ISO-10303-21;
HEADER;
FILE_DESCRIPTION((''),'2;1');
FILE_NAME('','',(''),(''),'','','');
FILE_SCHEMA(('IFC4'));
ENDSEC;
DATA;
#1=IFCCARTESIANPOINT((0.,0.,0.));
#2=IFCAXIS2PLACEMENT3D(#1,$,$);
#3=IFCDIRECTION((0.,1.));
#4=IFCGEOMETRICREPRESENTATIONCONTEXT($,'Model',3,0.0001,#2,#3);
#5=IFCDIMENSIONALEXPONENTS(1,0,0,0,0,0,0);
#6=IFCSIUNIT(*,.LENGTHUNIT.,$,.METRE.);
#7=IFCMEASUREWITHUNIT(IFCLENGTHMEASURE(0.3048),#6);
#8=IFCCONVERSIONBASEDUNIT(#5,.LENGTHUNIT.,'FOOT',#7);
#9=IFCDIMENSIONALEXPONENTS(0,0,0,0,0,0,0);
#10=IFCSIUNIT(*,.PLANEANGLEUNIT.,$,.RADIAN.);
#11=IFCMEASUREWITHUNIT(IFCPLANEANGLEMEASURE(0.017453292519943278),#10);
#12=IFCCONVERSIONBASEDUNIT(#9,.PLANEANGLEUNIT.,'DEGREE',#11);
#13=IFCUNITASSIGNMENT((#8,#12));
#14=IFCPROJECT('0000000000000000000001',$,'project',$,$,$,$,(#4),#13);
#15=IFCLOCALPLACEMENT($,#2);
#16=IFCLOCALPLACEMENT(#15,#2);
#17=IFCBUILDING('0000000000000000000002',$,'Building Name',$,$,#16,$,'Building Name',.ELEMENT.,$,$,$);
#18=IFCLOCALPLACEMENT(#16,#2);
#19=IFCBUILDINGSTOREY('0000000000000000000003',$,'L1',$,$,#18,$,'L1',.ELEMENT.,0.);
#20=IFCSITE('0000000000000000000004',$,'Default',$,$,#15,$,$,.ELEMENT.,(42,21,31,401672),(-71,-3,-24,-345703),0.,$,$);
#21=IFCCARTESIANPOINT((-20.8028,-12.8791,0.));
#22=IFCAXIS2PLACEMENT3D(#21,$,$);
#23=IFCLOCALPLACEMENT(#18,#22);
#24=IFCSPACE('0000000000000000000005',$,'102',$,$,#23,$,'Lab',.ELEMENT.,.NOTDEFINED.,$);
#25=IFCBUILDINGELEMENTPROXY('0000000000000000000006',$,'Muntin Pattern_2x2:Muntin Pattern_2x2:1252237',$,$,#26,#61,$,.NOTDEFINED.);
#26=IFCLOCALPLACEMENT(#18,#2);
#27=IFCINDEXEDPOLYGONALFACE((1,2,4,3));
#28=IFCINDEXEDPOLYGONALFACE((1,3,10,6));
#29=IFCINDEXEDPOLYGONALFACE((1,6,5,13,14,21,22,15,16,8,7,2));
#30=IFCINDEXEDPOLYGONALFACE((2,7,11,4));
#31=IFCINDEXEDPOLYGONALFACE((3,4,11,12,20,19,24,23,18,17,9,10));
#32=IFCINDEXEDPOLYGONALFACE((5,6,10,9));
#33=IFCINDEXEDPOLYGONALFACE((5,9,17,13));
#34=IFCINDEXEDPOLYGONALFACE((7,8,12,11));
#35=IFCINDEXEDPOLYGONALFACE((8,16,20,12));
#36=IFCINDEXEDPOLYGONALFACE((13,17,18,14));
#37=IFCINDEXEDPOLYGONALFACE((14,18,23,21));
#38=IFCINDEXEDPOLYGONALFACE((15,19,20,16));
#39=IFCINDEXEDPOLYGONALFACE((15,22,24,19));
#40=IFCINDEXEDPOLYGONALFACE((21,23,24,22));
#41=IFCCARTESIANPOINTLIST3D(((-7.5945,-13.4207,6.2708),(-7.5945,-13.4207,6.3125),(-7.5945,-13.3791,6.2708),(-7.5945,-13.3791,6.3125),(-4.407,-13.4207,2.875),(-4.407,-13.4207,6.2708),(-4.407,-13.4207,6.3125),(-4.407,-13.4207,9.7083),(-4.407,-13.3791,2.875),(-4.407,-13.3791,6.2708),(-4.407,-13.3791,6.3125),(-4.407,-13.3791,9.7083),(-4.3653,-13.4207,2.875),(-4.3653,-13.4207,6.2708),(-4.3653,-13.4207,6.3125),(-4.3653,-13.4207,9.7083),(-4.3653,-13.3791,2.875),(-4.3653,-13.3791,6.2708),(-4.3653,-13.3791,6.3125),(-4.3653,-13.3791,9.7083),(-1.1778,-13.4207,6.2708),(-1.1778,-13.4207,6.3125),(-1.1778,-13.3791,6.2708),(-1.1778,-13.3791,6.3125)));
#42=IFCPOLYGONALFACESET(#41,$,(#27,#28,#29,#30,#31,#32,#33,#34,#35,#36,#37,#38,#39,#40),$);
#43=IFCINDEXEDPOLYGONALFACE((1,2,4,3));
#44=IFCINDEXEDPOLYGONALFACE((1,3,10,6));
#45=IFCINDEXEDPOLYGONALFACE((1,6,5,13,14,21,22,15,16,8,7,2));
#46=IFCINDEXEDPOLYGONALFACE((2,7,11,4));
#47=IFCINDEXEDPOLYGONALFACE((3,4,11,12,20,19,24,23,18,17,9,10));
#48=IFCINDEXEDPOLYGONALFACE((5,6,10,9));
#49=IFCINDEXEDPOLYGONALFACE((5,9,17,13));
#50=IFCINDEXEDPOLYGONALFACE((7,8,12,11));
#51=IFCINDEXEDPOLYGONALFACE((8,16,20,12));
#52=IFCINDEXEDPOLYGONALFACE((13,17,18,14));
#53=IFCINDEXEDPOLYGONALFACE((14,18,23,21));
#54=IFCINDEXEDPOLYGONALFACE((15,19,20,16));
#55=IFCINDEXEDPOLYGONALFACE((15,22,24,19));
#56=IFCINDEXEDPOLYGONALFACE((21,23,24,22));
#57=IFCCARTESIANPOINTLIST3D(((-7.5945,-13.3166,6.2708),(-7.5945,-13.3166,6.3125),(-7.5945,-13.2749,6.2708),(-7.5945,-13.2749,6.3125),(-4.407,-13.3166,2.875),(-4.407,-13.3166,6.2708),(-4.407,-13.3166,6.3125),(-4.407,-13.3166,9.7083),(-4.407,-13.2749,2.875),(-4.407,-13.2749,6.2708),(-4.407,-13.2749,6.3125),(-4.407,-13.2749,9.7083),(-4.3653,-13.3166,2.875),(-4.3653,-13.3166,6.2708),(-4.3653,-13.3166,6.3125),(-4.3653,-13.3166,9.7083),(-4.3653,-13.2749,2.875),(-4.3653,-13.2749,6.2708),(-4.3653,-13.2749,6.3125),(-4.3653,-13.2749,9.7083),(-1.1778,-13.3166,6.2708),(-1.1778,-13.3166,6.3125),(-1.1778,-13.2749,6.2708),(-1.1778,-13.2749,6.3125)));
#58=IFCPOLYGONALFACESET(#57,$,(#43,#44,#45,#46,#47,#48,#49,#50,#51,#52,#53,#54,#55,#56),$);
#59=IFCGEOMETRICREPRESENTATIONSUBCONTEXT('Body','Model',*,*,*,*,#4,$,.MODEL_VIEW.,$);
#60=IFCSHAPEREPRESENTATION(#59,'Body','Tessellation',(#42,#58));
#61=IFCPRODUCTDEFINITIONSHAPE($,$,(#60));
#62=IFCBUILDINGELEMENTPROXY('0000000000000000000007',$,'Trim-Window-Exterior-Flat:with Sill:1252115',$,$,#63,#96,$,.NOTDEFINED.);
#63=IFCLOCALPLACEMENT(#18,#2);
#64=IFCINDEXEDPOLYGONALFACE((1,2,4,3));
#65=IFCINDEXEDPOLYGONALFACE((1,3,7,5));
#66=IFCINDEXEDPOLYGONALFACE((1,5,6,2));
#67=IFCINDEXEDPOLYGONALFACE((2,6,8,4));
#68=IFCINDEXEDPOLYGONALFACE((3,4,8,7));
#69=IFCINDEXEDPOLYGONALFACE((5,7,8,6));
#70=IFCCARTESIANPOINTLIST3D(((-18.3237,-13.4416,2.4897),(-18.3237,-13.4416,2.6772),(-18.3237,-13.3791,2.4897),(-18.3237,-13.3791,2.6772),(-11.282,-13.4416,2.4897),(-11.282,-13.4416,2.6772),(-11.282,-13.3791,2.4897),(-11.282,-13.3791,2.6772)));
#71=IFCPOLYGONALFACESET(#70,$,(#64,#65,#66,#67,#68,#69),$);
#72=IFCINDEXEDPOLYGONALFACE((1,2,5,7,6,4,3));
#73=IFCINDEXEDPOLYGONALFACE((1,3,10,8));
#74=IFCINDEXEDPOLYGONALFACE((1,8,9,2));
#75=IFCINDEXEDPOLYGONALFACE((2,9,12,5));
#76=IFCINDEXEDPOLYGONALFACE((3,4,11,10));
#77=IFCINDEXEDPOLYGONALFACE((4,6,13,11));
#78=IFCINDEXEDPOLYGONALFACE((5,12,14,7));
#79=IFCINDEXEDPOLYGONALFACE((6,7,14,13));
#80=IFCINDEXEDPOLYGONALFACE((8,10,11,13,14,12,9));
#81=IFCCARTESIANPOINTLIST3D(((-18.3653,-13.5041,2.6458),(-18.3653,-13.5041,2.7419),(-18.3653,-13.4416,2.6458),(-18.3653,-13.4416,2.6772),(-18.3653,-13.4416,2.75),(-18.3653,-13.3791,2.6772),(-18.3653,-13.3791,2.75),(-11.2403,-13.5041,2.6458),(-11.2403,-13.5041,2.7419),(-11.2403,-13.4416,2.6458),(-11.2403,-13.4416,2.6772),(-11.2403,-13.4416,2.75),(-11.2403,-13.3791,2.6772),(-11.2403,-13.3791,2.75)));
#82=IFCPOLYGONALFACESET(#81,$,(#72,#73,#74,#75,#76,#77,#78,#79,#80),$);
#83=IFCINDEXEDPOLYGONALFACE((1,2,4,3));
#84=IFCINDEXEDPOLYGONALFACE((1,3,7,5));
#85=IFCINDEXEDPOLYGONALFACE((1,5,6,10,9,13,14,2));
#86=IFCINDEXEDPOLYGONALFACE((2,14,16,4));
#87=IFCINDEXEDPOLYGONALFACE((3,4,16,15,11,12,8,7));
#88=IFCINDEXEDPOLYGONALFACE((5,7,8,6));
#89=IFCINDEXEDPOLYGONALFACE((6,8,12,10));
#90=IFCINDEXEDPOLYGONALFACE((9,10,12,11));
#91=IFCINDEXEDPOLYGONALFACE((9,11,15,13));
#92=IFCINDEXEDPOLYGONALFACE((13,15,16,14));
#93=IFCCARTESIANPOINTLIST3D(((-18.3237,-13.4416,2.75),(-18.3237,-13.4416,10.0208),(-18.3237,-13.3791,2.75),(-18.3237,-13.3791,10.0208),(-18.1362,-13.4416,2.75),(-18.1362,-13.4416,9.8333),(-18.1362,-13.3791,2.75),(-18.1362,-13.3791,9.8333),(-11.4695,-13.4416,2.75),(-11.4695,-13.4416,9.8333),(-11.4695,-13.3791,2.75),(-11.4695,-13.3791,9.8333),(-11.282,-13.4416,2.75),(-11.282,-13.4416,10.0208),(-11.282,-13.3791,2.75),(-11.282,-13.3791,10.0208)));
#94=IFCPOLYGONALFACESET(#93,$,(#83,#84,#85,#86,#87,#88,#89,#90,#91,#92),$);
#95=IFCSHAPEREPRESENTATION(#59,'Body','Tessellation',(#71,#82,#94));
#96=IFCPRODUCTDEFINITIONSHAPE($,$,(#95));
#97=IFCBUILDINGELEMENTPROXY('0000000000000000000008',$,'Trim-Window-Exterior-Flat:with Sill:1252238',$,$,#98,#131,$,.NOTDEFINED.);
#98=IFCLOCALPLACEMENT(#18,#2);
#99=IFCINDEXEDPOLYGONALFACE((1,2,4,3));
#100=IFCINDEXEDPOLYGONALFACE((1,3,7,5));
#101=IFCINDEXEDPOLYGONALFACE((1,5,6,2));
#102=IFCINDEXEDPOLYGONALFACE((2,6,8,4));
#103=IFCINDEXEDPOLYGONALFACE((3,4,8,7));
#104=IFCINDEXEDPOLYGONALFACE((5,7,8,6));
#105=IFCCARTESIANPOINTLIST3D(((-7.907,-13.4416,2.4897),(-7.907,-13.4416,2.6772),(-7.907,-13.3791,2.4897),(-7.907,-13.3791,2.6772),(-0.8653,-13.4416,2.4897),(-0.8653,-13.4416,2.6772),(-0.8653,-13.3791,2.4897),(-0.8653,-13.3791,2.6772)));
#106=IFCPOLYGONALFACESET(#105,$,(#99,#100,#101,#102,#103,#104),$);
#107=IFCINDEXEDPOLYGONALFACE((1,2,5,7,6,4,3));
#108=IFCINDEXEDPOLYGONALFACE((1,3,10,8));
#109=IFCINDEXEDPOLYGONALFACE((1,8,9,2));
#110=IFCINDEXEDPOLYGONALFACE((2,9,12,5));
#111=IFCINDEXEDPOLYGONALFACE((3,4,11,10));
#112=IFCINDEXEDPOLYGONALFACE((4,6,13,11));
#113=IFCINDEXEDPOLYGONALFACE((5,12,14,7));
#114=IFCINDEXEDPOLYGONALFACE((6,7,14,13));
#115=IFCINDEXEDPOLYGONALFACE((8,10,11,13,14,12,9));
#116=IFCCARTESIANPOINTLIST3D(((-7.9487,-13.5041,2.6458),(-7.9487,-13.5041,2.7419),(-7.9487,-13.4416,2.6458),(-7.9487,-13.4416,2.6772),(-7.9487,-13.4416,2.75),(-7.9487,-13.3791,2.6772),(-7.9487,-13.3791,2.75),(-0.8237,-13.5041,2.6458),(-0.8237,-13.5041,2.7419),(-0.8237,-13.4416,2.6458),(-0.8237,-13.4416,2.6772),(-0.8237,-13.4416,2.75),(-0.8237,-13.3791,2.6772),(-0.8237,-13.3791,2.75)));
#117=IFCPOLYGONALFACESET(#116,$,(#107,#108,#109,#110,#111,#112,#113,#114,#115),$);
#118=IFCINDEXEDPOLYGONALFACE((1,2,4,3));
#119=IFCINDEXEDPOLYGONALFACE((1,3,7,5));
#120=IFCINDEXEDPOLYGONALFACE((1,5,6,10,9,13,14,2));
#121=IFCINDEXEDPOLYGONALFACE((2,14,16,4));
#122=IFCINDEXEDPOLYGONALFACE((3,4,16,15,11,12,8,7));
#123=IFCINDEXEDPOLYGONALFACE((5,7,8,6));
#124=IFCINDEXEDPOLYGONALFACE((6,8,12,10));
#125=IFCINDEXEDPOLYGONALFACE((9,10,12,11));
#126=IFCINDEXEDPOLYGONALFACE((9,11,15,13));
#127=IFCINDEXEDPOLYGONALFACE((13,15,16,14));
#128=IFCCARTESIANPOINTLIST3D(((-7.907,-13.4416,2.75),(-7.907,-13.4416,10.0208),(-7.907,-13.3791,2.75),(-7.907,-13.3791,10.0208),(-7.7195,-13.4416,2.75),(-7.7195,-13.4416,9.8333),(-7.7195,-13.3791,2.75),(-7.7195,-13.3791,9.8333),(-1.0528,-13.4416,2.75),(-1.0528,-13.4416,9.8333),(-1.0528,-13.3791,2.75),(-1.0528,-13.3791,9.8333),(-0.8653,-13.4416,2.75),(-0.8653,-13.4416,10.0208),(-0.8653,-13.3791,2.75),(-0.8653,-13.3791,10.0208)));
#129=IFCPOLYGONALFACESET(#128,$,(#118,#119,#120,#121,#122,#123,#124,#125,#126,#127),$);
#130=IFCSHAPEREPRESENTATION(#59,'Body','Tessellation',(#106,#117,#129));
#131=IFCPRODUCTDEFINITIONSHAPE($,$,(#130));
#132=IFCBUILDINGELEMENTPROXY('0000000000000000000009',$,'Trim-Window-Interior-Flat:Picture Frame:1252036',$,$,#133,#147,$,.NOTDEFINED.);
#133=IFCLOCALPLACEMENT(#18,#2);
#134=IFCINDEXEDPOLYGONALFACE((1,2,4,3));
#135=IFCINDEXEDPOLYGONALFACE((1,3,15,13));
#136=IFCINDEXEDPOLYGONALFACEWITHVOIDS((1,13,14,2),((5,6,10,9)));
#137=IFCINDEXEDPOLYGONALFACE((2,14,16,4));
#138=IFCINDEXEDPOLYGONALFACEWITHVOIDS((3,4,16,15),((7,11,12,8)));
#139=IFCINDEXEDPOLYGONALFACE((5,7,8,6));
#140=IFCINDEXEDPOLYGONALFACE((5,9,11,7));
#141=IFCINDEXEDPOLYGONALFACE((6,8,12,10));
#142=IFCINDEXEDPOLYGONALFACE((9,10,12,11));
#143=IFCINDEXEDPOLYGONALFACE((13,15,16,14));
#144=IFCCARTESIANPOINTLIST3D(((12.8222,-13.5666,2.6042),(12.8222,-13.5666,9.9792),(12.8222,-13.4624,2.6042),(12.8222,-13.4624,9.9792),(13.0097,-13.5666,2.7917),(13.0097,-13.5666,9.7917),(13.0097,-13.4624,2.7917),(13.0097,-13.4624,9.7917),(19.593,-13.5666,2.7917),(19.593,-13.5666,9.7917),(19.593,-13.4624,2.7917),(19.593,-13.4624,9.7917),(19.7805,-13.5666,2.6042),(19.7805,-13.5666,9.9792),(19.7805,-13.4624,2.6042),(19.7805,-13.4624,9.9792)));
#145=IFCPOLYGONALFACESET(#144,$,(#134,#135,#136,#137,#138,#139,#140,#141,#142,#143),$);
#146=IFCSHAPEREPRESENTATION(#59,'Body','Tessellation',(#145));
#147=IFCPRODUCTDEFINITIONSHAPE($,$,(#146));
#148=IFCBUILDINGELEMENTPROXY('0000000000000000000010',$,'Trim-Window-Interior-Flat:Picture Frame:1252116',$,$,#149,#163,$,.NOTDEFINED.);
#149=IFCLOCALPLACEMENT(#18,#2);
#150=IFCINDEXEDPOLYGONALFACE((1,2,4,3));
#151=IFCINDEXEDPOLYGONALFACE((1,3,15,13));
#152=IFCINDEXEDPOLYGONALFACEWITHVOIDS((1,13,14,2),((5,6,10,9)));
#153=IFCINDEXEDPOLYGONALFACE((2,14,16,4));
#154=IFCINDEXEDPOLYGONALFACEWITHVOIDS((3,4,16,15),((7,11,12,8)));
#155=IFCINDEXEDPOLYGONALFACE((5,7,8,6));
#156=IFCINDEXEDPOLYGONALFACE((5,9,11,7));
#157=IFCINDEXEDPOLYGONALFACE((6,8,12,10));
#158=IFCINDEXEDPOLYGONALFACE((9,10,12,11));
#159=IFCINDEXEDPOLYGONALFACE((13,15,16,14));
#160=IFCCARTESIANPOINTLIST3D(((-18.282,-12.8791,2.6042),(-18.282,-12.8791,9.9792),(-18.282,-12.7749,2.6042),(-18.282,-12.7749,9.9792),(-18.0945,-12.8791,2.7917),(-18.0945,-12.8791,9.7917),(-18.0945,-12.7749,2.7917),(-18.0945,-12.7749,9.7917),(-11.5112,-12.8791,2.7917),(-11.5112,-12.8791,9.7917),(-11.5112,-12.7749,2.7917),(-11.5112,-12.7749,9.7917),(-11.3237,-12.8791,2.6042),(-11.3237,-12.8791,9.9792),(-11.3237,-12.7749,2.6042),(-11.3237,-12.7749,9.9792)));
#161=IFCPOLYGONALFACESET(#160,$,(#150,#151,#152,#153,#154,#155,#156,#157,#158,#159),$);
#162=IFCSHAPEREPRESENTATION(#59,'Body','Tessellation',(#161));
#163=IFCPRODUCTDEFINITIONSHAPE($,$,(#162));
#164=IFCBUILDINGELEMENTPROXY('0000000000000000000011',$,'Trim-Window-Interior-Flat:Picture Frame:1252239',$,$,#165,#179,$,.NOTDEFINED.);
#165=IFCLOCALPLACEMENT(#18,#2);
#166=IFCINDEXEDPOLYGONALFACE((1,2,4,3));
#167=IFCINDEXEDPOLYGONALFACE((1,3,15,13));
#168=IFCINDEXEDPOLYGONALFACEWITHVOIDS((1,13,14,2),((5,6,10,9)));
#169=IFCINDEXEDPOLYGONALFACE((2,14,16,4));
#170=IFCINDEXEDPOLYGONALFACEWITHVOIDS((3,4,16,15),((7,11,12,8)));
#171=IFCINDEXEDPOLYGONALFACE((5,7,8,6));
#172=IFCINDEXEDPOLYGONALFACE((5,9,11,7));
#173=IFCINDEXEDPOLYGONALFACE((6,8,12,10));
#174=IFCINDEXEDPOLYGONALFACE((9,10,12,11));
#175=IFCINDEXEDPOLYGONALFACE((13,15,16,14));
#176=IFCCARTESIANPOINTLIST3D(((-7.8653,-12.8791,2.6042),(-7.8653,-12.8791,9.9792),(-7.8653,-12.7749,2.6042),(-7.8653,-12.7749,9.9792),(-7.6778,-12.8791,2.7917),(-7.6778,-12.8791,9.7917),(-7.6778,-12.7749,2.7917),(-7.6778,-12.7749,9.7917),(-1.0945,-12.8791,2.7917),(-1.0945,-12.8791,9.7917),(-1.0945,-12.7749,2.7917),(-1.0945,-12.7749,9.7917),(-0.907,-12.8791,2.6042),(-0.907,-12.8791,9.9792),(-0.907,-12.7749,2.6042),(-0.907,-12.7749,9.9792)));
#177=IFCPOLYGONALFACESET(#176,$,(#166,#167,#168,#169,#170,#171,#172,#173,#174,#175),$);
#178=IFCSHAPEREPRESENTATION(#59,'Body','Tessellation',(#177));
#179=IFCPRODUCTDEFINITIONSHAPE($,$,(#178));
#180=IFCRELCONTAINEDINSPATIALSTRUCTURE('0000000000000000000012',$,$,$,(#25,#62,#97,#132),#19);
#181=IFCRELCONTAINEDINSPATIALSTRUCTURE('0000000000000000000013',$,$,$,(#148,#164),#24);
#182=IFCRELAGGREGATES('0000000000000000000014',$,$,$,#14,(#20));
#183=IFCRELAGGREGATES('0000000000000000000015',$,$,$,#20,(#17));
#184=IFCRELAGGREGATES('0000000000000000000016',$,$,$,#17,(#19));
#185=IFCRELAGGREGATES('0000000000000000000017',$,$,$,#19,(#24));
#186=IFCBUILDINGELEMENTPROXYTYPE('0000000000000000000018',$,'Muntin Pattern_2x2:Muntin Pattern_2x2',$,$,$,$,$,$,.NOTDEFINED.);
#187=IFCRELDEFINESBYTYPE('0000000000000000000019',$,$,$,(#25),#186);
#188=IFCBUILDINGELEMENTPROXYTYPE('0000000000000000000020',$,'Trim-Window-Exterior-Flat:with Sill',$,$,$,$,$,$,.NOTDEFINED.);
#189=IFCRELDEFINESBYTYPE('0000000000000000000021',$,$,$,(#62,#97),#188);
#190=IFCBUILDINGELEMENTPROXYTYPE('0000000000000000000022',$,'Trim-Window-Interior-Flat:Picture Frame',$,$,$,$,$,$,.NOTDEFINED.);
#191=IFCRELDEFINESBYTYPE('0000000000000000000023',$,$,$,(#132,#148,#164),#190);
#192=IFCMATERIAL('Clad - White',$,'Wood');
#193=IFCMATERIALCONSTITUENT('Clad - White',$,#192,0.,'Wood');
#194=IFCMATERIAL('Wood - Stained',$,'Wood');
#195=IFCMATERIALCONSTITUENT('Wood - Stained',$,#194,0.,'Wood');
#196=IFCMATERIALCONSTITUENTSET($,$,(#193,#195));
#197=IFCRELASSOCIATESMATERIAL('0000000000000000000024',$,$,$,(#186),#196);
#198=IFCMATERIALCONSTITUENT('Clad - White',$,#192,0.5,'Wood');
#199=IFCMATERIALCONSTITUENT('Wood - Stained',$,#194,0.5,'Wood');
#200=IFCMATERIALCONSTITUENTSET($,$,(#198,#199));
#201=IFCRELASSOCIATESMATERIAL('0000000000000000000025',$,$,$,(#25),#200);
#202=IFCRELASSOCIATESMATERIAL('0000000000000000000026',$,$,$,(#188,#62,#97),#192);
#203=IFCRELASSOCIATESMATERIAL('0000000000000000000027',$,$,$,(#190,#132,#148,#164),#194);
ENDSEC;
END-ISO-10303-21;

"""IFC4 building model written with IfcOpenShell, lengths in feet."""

from ifc_helpers import new_model, entity, si_unit, converted_unit, direction, frame, origin, place, context, subcontext, project, spatial, indexed_curve, outline, extrude, source, transform, mapped, material, constituent, constituent_set, type_object, type_shapes, element, save


model = new_model("IFC4")

# Units and contexts
model_context = context("Model", 3, precision=0.0001, world=origin(), true_north=direction((0.0, 1.0)))
body_context = subcontext(model_context, "Body", "Model", "MODEL_VIEW")
ifc_project = project(units=[converted_unit("LENGTHUNIT", "FOOT", entity("IfcLengthMeasure", 0.3048), si_unit("LENGTHUNIT", "METRE"), dimensions=[1, 0, 0, 0, 0, 0, 0]), converted_unit("PLANEANGLEUNIT", "DEGREE", entity("IfcPlaneAngleMeasure", 0.017453292519943278), si_unit("PLANEANGLEUNIT", "RADIAN"), dimensions=[0, 0, 0, 0, 0, 0, 0])], contexts=[model_context])

# Site, building, storey
site_placement = place(None, origin())
site = spatial("IfcSite", under=ifc_project, at=site_placement, Name="Default", CompositionType="ELEMENT", RefLatitude=(42, 21, 31, 401672), RefLongitude=(-71, -3, -24, -345703), RefElevation=0.0)
building_placement = place(site_placement, origin())
building = spatial("IfcBuilding", under=site, at=building_placement, Name="Building Name", LongName="Building Name", CompositionType="ELEMENT")
storey_placement = place(building_placement, origin())
storey = spatial("IfcBuildingStorey", under=building, at=storey_placement, Name="L1", LongName="L1", CompositionType="ELEMENT", Elevation=0.0)

# Building element proxy
ifc_material_1 = material(Name="Clad - White", Category="Wood")
ifc_material_2 = material(Name="Wood - Stained", Category="Wood")
ifc_constituent_1 = constituent(ifc_material_1, Name="Clad - White", Category="Wood", fraction=0.0)
ifc_constituent_2 = constituent(ifc_material_2, Name="Wood - Stained", Category="Wood", fraction=0.0)
ifc_constituent_set_1 = constituent_set(constituents=[ifc_constituent_1, ifc_constituent_2])
building_element_proxy_type_1 = type_object("IfcBuildingElementProxyType", Name="Muntin Pattern_2x2:Muntin Pattern_2x2", PredefinedType="NOTDEFINED", material=ifc_constituent_set_1)
shared_shape_1 = source(origin(), body_context, "Body", "SweptSolid", [
    extrude(outline(indexed_curve([(0.0208, -0.0208), (3.4167, -0.0208), (3.4167, 0.0208), (0.0208, 0.0208), (0.0208, 3.2083), (-0.0208, 3.2083), (-0.0208, 0.0208), (-3.4167, 0.0208), (-3.4167, -0.0208), (-0.0208, -0.0208), (-0.0208, -3.2083), (0.0208, -3.2083), (0.0208, -0.0208)], self_intersect=False)), frame((0.0, -0.0729, 3.4167), z_axis=(0.0, 1.0, 0.0), x_axis=(0.0, 0.0, 1.0)), (0.0, 0.0, 1.0), 0.0417),
    extrude(outline(indexed_curve([(0.0208, -0.0208), (3.4167, -0.0208), (3.4167, 0.0208), (0.0208, 0.0208), (0.0208, 3.2083), (-0.0208, 3.2083), (-0.0208, 0.0208), (-3.4167, 0.0208), (-3.4167, -0.0208), (-0.0208, -0.0208), (-0.0208, -3.2083), (0.0208, -3.2083), (0.0208, -0.0208)], self_intersect=False)), frame((0.0, 0.0313, 3.4167), z_axis=(0.0, 1.0, 0.0), x_axis=(0.0, 0.0, 1.0)), (0.0, 0.0, 1.0), 0.0417),
])
type_shapes(building_element_proxy_type_1, [shared_shape_1])
ifc_constituent_3 = constituent(ifc_material_1, Name="Clad - White", Category="Wood", fraction=0.5)
ifc_constituent_4 = constituent(ifc_material_2, Name="Wood - Stained", Category="Wood", fraction=0.5)
ifc_constituent_set_2 = constituent_set(constituents=[ifc_constituent_3, ifc_constituent_4])
proxy_1_placement = place(storey_placement, frame((-4.3862, -13.3478, 2.875)))
element("IfcBuildingElementProxy", 1, at=proxy_1_placement, inside=storey, type_object=building_element_proxy_type_1, material=ifc_constituent_set_2, Name="Muntin Pattern_2x2:Muntin Pattern_2x2:1252237", PredefinedType="NOTDEFINED", context=body_context, shape_type="MappedRepresentation", body=[
    mapped(shared_shape_1, transform((0.0, 0.0, 0.0), scale=1.0)),
])

# Building element proxies
building_element_proxy_type_2 = type_object("IfcBuildingElementProxyType", Name="Trim-Window-Exterior-Flat:with Sill", PredefinedType="NOTDEFINED", material=ifc_material_1)
shared_shape_2 = source(origin(), body_context, "Body", "SweptSolid", [
    extrude(outline(indexed_curve([(-3.5208, -0.0938), (3.5208, -0.0938), (3.5208, 0.0938), (-3.5208, 0.0938), (-3.5208, -0.0938)], self_intersect=False)), frame((0.0, -7.2499, 0.0), z_axis=(0.0, 0.0, 1.0), x_axis=(-1.0, 0.0, 0.0)), (0.0, 0.0, 1.0), 0.0625),
    extrude(outline(indexed_curve([(-0.0625, -0.0525), (0.0, -0.0525), (0.0, -0.0211), (0.0625, -0.0211), (0.0625, 0.0517), (0.0, 0.0517), (-0.0625, 0.0436), (-0.0625, -0.0525)], self_intersect=False)), frame((-3.5625, -7.135, 0.0625), z_axis=(1.0, 0.0, 0.0), x_axis=(0.0, 0.0, -1.0)), (0.0, 0.0, 1.0), 7.125),
    extrude(outline(indexed_curve([(-3.6823, -3.5208), (3.5885, -3.5208), (3.5885, -3.3333), (-3.4948, -3.3333), (-3.4948, 3.3333), (3.5885, 3.3333), (3.5885, 3.5208), (-3.6823, 3.5208), (-3.6823, -3.5208)], self_intersect=False)), frame((0.0, -3.4948, 0.0), z_axis=(0.0, 0.0, 1.0), x_axis=(0.0, -1.0, 0.0)), (0.0, 0.0, 1.0), 0.0625),
])
type_shapes(building_element_proxy_type_2, [shared_shape_2])
for number, where, z_axis, x_axis, name in (
    (2, (-14.8028, -13.3791, 9.8333), (0.0, -1.0, 0.0), (1.0, 0.0, 0.0), "Trim-Window-Exterior-Flat:with Sill:1252115"),
    (3, (-4.3862, -13.3791, 9.8333), (0.0, -1.0, 0.0), (1.0, 0.0, 0.0), "Trim-Window-Exterior-Flat:with Sill:1252238"),
):
    element("IfcBuildingElementProxy", number, at=place(storey_placement, frame(where, z_axis=z_axis, x_axis=x_axis)), inside=storey, type_object=building_element_proxy_type_2, material=ifc_material_1, Name=name, PredefinedType="NOTDEFINED", context=body_context, shape_type="MappedRepresentation", body=[
        mapped(shared_shape_2, transform((0.0, 0.0, 0.0), scale=1.0)),
    ])
building_element_proxy_type_3 = type_object("IfcBuildingElementProxyType", Name="Trim-Window-Interior-Flat:Picture Frame", PredefinedType="NOTDEFINED", material=ifc_material_2)
shared_shape_3 = source(origin(), body_context, "Body", "SweptSolid", [
    extrude(outline(indexed_curve([(-3.4792, -3.6875), (3.4792, -3.6875), (3.4792, 3.6875), (-3.4792, 3.6875), (-3.4792, -3.6875)], self_intersect=False), holes=[indexed_curve([(-3.2917, -3.5), (-3.2917, 3.5), (3.2917, 3.5), (3.2917, -3.5), (-3.2917, -3.5)], self_intersect=False)]), frame((0.0, -3.5417, 0.0), z_axis=(0.0, 0.0, 1.0), x_axis=(-1.0, 0.0, 0.0)), (0.0, 0.0, 1.0), 0.1042),
])
type_shapes(building_element_proxy_type_3, [shared_shape_3])
proxy_2_placement = place(storey_placement, frame((16.3013, -13.4624, 9.8333), z_axis=(0.0, -1.0, 0.0), x_axis=(1.0, 0.0, 0.0)))
element("IfcBuildingElementProxy", 4, at=proxy_2_placement, inside=storey, type_object=building_element_proxy_type_3, material=ifc_material_2, Name="Trim-Window-Interior-Flat:Picture Frame:1252036", PredefinedType="NOTDEFINED", context=body_context, shape_type="MappedRepresentation", body=[
    mapped(shared_shape_3, transform((0.0, 0.0, 0.0), scale=1.0)),
])

# Shared definitions
space_1_placement = place(storey_placement, frame((-20.8028, -12.8791, 0.0)))
space_1 = spatial("IfcSpace", under=storey, at=space_1_placement, Name="102", LongName="Lab", CompositionType="ELEMENT", PredefinedType="NOTDEFINED")

# Building element proxies
for number, where, z_axis, x_axis, name in (
    (5, (6.0, 0.0, 9.8333), (0.0, 1.0, 0.0), (-1.0, 0.0, 0.0), "Trim-Window-Interior-Flat:Picture Frame:1252116"),
    (6, (16.4167, 0.0, 9.8333), (0.0, 1.0, 0.0), (-1.0, 0.0, 0.0), "Trim-Window-Interior-Flat:Picture Frame:1252239"),
):
    element("IfcBuildingElementProxy", number, at=place(space_1_placement, frame(where, z_axis=z_axis, x_axis=x_axis)), inside=space_1, type_object=building_element_proxy_type_3, material=ifc_material_2, Name=name, PredefinedType="NOTDEFINED", context=body_context, shape_type="MappedRepresentation", body=[
        mapped(shared_shape_3, transform((0.0, 0.0, 0.0), scale=1.0)),
    ])

save(model, "model.ifc")
